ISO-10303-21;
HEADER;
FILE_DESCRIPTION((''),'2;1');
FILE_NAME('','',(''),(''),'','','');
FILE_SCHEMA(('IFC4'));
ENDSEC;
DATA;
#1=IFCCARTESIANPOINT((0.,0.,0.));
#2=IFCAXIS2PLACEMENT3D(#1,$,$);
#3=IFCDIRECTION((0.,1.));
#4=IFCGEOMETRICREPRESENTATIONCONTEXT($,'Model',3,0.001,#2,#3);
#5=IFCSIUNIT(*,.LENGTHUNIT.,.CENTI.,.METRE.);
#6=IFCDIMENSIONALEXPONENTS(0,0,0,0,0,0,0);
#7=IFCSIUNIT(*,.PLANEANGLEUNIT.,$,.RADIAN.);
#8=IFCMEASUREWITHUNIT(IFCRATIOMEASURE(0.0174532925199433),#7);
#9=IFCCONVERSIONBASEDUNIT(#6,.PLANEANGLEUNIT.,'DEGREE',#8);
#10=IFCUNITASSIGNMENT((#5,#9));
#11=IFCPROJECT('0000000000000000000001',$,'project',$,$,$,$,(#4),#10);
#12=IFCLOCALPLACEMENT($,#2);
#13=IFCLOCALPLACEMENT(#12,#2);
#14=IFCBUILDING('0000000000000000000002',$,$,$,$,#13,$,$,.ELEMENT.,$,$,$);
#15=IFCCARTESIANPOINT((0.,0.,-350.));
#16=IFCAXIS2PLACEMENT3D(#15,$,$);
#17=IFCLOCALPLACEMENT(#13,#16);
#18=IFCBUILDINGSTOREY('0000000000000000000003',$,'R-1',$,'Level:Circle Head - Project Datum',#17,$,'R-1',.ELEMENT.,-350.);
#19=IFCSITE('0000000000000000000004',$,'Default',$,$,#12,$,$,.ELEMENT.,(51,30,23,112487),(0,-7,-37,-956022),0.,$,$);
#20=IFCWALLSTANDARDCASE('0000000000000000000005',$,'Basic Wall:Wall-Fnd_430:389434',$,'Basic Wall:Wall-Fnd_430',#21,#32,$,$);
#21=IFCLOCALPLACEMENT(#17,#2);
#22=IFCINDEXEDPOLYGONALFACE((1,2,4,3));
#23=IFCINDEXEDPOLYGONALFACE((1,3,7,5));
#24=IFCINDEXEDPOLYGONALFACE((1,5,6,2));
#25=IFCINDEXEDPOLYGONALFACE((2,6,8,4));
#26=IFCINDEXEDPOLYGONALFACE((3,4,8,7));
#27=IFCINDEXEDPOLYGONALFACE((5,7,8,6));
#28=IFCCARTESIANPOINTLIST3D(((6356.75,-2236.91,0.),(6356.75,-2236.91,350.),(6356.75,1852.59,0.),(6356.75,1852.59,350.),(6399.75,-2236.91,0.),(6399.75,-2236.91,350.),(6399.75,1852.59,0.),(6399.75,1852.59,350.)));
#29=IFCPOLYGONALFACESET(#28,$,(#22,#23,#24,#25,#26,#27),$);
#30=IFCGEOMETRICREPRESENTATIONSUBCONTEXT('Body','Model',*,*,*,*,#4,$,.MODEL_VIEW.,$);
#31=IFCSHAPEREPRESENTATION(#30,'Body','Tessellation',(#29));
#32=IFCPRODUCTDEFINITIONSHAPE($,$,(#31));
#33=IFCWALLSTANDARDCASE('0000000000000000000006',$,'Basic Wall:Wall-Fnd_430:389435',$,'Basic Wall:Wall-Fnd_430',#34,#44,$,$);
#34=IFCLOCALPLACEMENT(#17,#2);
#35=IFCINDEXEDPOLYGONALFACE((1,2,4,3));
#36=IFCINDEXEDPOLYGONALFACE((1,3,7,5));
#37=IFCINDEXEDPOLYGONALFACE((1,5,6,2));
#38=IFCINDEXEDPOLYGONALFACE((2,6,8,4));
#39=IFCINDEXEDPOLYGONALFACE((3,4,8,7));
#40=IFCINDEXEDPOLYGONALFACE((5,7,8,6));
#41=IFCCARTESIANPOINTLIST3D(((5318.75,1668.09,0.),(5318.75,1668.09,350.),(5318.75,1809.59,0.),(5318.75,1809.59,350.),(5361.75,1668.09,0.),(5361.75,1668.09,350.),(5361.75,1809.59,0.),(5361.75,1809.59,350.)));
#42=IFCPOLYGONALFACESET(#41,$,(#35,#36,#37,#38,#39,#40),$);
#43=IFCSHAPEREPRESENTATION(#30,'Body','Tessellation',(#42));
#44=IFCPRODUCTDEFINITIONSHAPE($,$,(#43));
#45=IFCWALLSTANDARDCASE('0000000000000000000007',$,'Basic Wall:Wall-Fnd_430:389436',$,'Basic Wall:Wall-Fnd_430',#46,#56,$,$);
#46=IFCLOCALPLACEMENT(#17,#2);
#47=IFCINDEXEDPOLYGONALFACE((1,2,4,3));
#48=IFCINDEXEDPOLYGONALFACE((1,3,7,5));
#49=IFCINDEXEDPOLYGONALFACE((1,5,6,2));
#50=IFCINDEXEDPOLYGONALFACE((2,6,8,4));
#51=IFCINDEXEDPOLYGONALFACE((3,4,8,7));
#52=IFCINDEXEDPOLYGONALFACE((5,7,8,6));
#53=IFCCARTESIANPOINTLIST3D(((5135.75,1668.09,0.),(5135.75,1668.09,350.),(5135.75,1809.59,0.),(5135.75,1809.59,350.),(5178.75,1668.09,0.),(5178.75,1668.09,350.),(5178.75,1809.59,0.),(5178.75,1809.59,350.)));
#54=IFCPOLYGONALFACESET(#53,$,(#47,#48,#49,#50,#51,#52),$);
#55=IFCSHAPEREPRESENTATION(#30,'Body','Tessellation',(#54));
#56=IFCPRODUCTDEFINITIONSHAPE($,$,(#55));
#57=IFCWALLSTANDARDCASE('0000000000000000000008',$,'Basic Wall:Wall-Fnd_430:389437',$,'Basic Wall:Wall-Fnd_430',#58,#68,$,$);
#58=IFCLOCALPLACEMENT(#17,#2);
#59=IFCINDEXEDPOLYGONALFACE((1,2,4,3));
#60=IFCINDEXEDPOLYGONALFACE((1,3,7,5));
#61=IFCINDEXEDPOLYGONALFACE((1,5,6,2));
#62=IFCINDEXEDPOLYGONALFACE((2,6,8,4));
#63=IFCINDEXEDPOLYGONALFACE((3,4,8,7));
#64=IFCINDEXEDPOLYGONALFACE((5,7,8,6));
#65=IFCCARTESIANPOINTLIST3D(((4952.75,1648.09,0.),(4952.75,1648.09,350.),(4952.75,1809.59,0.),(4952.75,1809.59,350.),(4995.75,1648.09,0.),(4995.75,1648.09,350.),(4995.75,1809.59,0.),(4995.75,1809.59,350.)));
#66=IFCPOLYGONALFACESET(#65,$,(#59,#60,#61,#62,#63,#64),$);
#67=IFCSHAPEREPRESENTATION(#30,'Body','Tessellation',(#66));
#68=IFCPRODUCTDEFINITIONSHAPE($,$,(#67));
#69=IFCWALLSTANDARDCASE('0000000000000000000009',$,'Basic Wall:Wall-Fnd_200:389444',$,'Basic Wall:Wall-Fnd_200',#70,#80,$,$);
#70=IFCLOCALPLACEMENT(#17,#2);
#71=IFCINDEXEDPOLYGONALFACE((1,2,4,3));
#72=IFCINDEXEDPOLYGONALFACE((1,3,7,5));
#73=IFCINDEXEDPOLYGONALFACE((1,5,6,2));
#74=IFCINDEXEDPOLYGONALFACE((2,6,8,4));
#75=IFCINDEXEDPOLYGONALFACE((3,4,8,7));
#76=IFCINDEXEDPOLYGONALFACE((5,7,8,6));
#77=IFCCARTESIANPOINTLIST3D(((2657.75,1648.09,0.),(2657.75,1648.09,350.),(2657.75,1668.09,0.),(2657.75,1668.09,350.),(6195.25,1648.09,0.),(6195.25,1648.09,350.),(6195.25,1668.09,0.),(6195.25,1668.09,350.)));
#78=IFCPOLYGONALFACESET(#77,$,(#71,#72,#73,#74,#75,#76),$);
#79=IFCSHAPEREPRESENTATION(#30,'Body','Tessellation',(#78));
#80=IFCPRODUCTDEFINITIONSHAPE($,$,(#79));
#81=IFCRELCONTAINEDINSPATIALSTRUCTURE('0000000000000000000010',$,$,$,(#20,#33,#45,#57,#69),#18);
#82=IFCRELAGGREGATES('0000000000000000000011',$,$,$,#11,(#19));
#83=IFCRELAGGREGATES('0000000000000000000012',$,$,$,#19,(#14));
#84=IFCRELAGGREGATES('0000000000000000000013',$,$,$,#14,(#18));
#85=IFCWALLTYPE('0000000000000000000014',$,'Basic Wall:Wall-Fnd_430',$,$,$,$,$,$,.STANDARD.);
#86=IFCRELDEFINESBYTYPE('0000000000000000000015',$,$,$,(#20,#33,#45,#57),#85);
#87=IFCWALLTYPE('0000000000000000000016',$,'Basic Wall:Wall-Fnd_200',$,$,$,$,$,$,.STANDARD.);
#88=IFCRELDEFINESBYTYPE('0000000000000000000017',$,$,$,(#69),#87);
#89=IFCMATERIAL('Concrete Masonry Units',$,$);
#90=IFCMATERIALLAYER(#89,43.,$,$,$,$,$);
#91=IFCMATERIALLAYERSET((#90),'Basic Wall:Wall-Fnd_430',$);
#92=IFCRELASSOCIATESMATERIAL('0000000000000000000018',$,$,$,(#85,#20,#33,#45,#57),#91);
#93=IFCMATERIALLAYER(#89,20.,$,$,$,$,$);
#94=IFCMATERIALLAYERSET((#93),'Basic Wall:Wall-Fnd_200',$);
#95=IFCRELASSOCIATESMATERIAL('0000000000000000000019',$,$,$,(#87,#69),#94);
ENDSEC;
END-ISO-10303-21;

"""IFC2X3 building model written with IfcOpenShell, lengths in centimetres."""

from ifc_helpers import new_model, entity, si_unit, converted_unit, direction, frame, frame_2d, origin, place, context, subcontext, project, spatial, rectangle, extrude, material, layer, layer_set, layer_usage, type_object, element, save


model = new_model("IFC2X3")

# Units and contexts
model_context = context("Model", 3, precision=0.001, world=origin(), true_north=direction((0.0, 1.0)))
body_context = subcontext(model_context, "Body", "Model", "MODEL_VIEW")
ifc_project = project(units=[si_unit("LENGTHUNIT", "METRE", prefix="CENTI"), converted_unit("PLANEANGLEUNIT", "DEGREE", entity("IfcRatioMeasure", 0.0174532925199433), si_unit("PLANEANGLEUNIT", "RADIAN"), dimensions=[0, 0, 0, 0, 0, 0, 0])], contexts=[model_context])

# Site, building, storey
site_placement = place(None, origin())
site = spatial("IfcSite", under=ifc_project, at=site_placement, Name="Default", CompositionType="ELEMENT", RefLatitude=(51, 30, 23, 112487), RefLongitude=(0, -7, -37, -956022), RefElevation=0.0)
building_placement = place(site_placement, origin())
building = spatial("IfcBuilding", under=site, at=building_placement, CompositionType="ELEMENT")
storey_placement = place(building_placement, frame((0.0, 0.0, -350.0)))
storey = spatial("IfcBuildingStorey", under=building, at=storey_placement, Name="R-1", ObjectType="Level:Circle Head - Project Datum", LongName="R-1", CompositionType="ELEMENT", Elevation=-350.0)

# Walls
ifc_material_1 = material(Name="Concrete Masonry Units")
ifc_layer_1 = layer(ifc_material_1, 43.0)
ifc_layer_set_1 = layer_set([ifc_layer_1], Name="Basic Wall:Wall-Fnd_430")
ifc_layer_usage_1 = layer_usage(ifc_layer_set_1, "AXIS2", "POSITIVE", -21.5)
wall_type_1 = type_object("IfcWallType", Name="Basic Wall:Wall-Fnd_430", PredefinedType="STANDARD", material=ifc_layer_set_1)
wall_1_placement = place(storey_placement, frame((6378.25, 1852.59, 0.0), z_axis=(0.0, 0.0, 1.0), x_axis=(0.0, -1.0, 0.0)))
element("IfcWallStandardCase", 1, at=wall_1_placement, inside=storey, type_object=wall_type_1, material=ifc_layer_usage_1, Name="Basic Wall:Wall-Fnd_430:389434", ObjectType="Basic Wall:Wall-Fnd_430", context=body_context, shape_type="SweptSolid", body=[
    extrude(rectangle(XDim=4089.5, YDim=43.0, at=frame_2d((2044.75, 0.0), x_axis=(-1.0, 0.0))), origin(), (0.0, 0.0, 1.0), 350.0),
])
ifc_layer_usage_2 = layer_usage(ifc_layer_set_1, "AXIS2", "POSITIVE", -21.5)
wall_2_placement = place(storey_placement, frame((5340.25, 1809.59, 0.0), z_axis=(0.0, 0.0, 1.0), x_axis=(0.0, -1.0, 0.0)))
element("IfcWallStandardCase", 2, at=wall_2_placement, inside=storey, type_object=wall_type_1, material=ifc_layer_usage_2, Name="Basic Wall:Wall-Fnd_430:389435", ObjectType="Basic Wall:Wall-Fnd_430", context=body_context, shape_type="SweptSolid", body=[
    extrude(rectangle(XDim=141.5, YDim=43.0, at=frame_2d((70.75, 0.0), x_axis=(-1.0, 0.0))), origin(), (0.0, 0.0, 1.0), 350.0),
])
ifc_layer_usage_3 = layer_usage(ifc_layer_set_1, "AXIS2", "POSITIVE", -21.5)
wall_3_placement = place(storey_placement, frame((5157.25, 1809.59, 0.0), z_axis=(0.0, 0.0, 1.0), x_axis=(0.0, -1.0, 0.0)))
element("IfcWallStandardCase", 3, at=wall_3_placement, inside=storey, type_object=wall_type_1, material=ifc_layer_usage_3, Name="Basic Wall:Wall-Fnd_430:389436", ObjectType="Basic Wall:Wall-Fnd_430", context=body_context, shape_type="SweptSolid", body=[
    extrude(rectangle(XDim=141.5, YDim=43.0, at=frame_2d((70.75, 0.0), x_axis=(-1.0, 0.0))), origin(), (0.0, 0.0, 1.0), 350.0),
])
ifc_layer_usage_4 = layer_usage(ifc_layer_set_1, "AXIS2", "POSITIVE", -21.5)
wall_4_placement = place(storey_placement, frame((4974.25, 1648.09, 0.0), z_axis=(0.0, 0.0, 1.0), x_axis=(0.0, 1.0, 0.0)))
element("IfcWallStandardCase", 4, at=wall_4_placement, inside=storey, type_object=wall_type_1, material=ifc_layer_usage_4, Name="Basic Wall:Wall-Fnd_430:389437", ObjectType="Basic Wall:Wall-Fnd_430", context=body_context, shape_type="SweptSolid", body=[
    extrude(rectangle(XDim=161.5, YDim=43.0, at=frame_2d((80.75, 0.0), x_axis=(-1.0, 0.0))), origin(), (0.0, 0.0, 1.0), 350.0),
])
ifc_layer_2 = layer(ifc_material_1, 20.0)
ifc_layer_set_2 = layer_set([ifc_layer_2], Name="Basic Wall:Wall-Fnd_200")
ifc_layer_usage_5 = layer_usage(ifc_layer_set_2, "AXIS2", "NEGATIVE", 10.0)
wall_type_2 = type_object("IfcWallType", Name="Basic Wall:Wall-Fnd_200", PredefinedType="STANDARD", material=ifc_layer_set_2)
wall_5_placement = place(storey_placement, frame((6195.25, 1658.09, 0.0), z_axis=(0.0, 0.0, 1.0), x_axis=(-1.0, 0.0, 0.0)))
element("IfcWallStandardCase", 5, at=wall_5_placement, inside=storey, type_object=wall_type_2, material=ifc_layer_usage_5, Name="Basic Wall:Wall-Fnd_200:389444", ObjectType="Basic Wall:Wall-Fnd_200", context=body_context, shape_type="SweptSolid", body=[
    extrude(rectangle(XDim=3537.5, YDim=20.0, at=frame_2d((1768.75, 0.0), x_axis=(-1.0, 0.0))), origin(), (0.0, 0.0, 1.0), 350.0),
])

save(model, "model.ifc")
